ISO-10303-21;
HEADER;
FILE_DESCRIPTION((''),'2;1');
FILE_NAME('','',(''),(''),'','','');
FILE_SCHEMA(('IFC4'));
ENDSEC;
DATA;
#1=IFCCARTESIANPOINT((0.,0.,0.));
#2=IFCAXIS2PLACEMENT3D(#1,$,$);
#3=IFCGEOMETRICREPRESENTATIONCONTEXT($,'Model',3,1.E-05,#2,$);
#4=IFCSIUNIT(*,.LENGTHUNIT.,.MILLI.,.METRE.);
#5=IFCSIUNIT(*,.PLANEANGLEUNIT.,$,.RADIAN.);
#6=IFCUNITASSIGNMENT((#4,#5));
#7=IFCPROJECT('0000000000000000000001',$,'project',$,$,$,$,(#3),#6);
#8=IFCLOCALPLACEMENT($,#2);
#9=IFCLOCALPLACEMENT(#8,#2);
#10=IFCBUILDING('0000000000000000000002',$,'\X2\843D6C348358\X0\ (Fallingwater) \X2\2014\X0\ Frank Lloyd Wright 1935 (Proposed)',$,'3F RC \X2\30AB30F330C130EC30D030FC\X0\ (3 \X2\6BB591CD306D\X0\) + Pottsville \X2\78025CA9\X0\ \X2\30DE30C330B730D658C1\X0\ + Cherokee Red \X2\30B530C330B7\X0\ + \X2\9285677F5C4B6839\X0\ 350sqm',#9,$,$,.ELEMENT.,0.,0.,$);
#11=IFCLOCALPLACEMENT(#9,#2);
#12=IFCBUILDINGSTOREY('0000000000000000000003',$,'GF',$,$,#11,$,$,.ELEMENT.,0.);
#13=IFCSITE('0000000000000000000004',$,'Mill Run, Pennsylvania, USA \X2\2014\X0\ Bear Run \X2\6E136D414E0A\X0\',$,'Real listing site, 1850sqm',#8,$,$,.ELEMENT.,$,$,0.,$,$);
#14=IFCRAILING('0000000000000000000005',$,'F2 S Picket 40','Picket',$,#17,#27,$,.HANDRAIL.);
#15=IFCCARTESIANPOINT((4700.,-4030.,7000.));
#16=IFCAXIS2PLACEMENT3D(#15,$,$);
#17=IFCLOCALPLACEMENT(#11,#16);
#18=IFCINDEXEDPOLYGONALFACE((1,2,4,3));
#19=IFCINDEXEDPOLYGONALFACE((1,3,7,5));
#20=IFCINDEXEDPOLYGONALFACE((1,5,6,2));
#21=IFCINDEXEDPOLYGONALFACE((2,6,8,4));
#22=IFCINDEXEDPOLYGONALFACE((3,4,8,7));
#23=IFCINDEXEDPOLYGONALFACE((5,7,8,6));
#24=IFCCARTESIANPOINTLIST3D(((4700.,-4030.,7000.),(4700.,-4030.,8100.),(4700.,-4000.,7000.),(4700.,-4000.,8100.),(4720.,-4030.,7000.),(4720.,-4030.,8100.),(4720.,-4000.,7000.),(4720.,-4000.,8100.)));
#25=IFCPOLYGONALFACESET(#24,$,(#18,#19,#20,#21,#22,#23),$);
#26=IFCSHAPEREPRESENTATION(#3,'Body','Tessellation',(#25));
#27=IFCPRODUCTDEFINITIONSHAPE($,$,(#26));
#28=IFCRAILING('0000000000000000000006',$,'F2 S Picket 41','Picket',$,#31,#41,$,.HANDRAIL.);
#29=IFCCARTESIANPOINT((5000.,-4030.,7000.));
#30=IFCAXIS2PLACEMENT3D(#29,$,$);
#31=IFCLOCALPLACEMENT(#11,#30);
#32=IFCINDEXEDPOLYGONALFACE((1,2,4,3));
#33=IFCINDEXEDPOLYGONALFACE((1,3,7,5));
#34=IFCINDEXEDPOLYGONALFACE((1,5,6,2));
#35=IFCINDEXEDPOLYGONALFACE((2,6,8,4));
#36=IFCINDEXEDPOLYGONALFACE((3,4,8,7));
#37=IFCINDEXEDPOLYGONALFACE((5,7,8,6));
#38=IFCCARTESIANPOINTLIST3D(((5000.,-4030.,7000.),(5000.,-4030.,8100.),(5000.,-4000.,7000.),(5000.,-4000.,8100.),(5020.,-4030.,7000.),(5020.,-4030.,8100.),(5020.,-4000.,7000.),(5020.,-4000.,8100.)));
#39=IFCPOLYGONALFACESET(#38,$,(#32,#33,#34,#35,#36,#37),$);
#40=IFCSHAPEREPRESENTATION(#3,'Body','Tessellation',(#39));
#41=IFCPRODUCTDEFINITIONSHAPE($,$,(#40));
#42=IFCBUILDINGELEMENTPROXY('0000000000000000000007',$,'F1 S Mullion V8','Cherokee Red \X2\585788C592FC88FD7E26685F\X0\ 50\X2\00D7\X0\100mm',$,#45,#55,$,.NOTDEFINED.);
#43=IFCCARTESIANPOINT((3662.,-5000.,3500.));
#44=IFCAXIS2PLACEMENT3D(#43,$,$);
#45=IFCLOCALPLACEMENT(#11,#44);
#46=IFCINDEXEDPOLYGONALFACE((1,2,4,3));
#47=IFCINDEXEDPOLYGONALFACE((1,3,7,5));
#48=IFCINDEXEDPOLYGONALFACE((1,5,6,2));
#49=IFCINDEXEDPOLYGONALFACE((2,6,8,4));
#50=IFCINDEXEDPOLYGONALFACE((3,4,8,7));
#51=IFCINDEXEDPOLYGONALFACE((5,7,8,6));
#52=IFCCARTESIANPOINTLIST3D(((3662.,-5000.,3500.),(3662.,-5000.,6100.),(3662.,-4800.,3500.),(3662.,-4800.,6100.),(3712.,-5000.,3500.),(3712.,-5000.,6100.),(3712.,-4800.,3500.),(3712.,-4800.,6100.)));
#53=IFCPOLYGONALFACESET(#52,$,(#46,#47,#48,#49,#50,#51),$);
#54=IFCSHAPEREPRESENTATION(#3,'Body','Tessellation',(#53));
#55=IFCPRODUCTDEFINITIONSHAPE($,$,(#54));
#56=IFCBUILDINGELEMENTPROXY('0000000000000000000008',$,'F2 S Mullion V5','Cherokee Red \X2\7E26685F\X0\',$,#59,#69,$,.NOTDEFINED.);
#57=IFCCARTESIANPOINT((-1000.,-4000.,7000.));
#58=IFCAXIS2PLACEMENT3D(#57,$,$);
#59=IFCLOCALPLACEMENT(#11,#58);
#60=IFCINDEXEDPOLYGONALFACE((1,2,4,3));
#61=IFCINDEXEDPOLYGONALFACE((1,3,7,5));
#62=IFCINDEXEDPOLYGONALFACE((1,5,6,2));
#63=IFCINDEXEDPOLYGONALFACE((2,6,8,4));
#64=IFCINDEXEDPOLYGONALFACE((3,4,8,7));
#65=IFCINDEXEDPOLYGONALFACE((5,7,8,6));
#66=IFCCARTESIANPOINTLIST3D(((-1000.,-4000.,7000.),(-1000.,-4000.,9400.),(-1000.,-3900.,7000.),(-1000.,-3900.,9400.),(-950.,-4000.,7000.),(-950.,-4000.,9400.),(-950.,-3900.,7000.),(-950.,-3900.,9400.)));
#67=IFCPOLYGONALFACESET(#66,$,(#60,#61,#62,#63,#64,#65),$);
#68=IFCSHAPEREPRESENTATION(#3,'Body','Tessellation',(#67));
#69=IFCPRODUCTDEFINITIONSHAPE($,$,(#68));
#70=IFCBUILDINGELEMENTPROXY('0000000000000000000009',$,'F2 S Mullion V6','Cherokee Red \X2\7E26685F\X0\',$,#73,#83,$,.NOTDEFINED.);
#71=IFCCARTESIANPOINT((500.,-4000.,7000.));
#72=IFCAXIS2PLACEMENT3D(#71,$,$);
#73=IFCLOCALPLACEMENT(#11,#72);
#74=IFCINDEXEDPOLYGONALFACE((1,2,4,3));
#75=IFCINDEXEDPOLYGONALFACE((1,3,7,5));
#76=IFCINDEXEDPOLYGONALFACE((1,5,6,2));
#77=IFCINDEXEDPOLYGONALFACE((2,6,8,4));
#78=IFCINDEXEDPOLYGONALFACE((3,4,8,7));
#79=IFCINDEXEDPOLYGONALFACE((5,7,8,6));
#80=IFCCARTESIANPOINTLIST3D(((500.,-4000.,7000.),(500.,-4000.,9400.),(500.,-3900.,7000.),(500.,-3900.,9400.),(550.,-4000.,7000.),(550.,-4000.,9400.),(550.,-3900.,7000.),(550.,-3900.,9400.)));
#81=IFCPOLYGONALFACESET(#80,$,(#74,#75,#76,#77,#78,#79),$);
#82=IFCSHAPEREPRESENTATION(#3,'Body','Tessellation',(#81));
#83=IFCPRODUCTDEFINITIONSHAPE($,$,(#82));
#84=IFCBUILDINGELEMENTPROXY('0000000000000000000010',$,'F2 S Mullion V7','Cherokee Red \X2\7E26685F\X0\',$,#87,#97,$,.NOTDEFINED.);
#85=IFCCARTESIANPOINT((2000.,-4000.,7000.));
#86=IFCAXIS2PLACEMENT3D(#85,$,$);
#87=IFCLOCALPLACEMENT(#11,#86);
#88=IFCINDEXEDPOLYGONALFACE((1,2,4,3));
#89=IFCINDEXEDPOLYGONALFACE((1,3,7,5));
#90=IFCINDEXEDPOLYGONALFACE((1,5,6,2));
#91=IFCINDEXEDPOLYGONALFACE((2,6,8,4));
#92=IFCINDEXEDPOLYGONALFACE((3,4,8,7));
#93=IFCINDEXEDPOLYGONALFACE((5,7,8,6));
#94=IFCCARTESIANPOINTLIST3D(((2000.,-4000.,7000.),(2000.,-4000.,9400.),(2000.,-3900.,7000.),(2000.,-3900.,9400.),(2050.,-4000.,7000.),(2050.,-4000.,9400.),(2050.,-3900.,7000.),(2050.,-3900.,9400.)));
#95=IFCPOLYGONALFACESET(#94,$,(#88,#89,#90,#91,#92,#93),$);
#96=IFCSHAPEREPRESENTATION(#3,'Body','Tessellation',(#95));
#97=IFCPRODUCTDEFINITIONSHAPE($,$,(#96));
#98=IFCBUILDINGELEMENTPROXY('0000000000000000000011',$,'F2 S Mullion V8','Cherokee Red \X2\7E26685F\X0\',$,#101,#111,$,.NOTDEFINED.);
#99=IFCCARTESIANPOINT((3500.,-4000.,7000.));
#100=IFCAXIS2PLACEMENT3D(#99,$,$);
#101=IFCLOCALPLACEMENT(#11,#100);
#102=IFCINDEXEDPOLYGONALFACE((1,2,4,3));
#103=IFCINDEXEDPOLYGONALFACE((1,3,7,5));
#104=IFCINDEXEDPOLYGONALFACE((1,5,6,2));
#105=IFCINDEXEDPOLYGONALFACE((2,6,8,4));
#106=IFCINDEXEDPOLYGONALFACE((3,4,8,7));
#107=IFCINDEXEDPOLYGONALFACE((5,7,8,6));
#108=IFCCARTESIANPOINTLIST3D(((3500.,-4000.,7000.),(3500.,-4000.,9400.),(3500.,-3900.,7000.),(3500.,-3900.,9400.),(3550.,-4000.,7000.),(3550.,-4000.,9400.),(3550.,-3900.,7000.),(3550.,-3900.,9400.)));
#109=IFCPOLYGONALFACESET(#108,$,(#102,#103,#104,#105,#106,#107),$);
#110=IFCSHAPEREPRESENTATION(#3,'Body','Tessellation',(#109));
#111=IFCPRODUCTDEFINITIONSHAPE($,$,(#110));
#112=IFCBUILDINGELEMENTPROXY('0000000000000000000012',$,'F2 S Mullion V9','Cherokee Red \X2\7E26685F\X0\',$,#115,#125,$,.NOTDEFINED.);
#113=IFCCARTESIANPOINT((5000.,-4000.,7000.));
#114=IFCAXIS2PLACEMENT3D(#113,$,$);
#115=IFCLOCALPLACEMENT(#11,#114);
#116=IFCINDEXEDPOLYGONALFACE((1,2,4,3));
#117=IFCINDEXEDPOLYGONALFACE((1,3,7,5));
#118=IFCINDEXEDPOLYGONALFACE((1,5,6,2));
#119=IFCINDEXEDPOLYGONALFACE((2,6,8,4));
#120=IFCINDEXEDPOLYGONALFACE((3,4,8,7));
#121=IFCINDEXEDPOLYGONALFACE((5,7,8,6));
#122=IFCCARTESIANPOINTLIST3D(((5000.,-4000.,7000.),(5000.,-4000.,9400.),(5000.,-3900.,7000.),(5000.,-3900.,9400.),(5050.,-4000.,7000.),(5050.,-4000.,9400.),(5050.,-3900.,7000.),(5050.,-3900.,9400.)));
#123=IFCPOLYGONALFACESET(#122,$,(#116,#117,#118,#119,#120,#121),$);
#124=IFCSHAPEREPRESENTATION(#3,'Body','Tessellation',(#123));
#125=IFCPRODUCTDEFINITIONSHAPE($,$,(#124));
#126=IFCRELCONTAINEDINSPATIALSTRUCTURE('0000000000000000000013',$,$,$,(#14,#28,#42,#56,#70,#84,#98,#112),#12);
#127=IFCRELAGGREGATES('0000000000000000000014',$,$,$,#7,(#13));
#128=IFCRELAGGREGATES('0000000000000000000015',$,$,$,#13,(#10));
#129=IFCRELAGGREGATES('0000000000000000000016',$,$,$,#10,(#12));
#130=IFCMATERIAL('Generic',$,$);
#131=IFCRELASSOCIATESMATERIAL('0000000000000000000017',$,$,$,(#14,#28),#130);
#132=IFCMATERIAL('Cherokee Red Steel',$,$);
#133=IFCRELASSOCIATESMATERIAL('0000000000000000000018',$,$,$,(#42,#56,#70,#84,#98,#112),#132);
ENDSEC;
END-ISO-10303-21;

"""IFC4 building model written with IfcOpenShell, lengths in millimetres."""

from ifc_helpers import new_model, si_unit, frame, frame_2d, origin, place, context, project, spatial, rectangle, extrude, material, element, save


model = new_model("IFC4")

# Units and contexts
model_context = context("Model", 3, precision=1e-05, world=origin())
ifc_project = project(units=[si_unit("LENGTHUNIT", "METRE", prefix="MILLI"), si_unit("PLANEANGLEUNIT", "RADIAN")], contexts=[model_context])

# Site, building, storey
site_placement = place(None, origin())
site = spatial("IfcSite", under=ifc_project, at=site_placement, Name="Mill Run, Pennsylvania, USA — Bear Run 渓流上", ObjectType="Real listing site, 1850sqm", CompositionType="ELEMENT", RefElevation=0.0)
building_placement = place(site_placement, origin())
building = spatial("IfcBuilding", under=site, at=building_placement, Name="落水荘 (Fallingwater) — Frank Lloyd Wright 1935 (Proposed)", ObjectType="3F RC カンチレバー (3 段重ね) + Pottsville 砂岩 マッシブ壁 + Cherokee Red サッシ + 銅板屋根 350sqm", CompositionType="ELEMENT", ElevationOfRefHeight=0.0, ElevationOfTerrain=0.0)
storey_placement = place(building_placement, origin())
storey = spatial("IfcBuildingStorey", under=building, at=storey_placement, Name="GF", CompositionType="ELEMENT", Elevation=0.0)

# Shared definitions
ifc_material_1 = material(Name="Cherokee Red Steel")

# Railings
ifc_material_2 = material(Name="Generic")
railing_1_placement = place(storey_placement, frame((4700.0, -4030.0, 7000.0)))
element("IfcRailing", 1, at=railing_1_placement, inside=storey, material=ifc_material_2, Name="F2 S Picket 40", Description="Picket", PredefinedType="HANDRAIL", context=model_context, shape_type="SweptSolid", body=[
    extrude(rectangle(XDim=20.0, YDim=30.0, at=frame_2d((10.0, 15.0))), frame((4700.0, -4030.0, 7000.0)), (0.0, 0.0, 1.0), 1100.0),
])
railing_2_placement = place(storey_placement, frame((5000.0, -4030.0, 7000.0)))
element("IfcRailing", 2, at=railing_2_placement, inside=storey, material=ifc_material_2, Name="F2 S Picket 41", Description="Picket", PredefinedType="HANDRAIL", context=model_context, shape_type="SweptSolid", body=[
    extrude(rectangle(XDim=20.0, YDim=30.0, at=frame_2d((10.0, 15.0))), frame((5000.0, -4030.0, 7000.0)), (0.0, 0.0, 1.0), 1100.0),
])

# Building element proxies
proxy_1_placement = place(storey_placement, frame((3662.0, -5000.0, 3500.0)))
element("IfcBuildingElementProxy", 3, at=proxy_1_placement, inside=storey, material=ifc_material_1, Name="F1 S Mullion V8", Description="Cherokee Red 塗装鋼製縦桟 50×100mm", PredefinedType="NOTDEFINED", context=model_context, shape_type="SweptSolid", body=[
    extrude(rectangle(XDim=50.0, YDim=200.0, at=frame_2d((25.0, 100.0))), frame((3662.0, -5000.0, 3500.0)), (0.0, 0.0, 1.0), 2600.0),
])
proxy_2_placement = place(storey_placement, frame((-1000.0, -4000.0, 7000.0)))
element("IfcBuildingElementProxy", 4, at=proxy_2_placement, inside=storey, material=ifc_material_1, Name="F2 S Mullion V5", Description="Cherokee Red 縦桟", PredefinedType="NOTDEFINED", context=model_context, shape_type="SweptSolid", body=[
    extrude(rectangle(XDim=50.0, YDim=100.0, at=frame_2d((25.0, 50.0))), frame((-1000.0, -4000.0, 7000.0)), (0.0, 0.0, 1.0), 2400.0),
])
proxy_3_placement = place(storey_placement, frame((500.0, -4000.0, 7000.0)))
element("IfcBuildingElementProxy", 5, at=proxy_3_placement, inside=storey, material=ifc_material_1, Name="F2 S Mullion V6", Description="Cherokee Red 縦桟", PredefinedType="NOTDEFINED", context=model_context, shape_type="SweptSolid", body=[
    extrude(rectangle(XDim=50.0, YDim=100.0, at=frame_2d((25.0, 50.0))), frame((500.0, -4000.0, 7000.0)), (0.0, 0.0, 1.0), 2400.0),
])
proxy_4_placement = place(storey_placement, frame((2000.0, -4000.0, 7000.0)))
element("IfcBuildingElementProxy", 6, at=proxy_4_placement, inside=storey, material=ifc_material_1, Name="F2 S Mullion V7", Description="Cherokee Red 縦桟", PredefinedType="NOTDEFINED", context=model_context, shape_type="SweptSolid", body=[
    extrude(rectangle(XDim=50.0, YDim=100.0, at=frame_2d((25.0, 50.0))), frame((2000.0, -4000.0, 7000.0)), (0.0, 0.0, 1.0), 2400.0),
])
proxy_5_placement = place(storey_placement, frame((3500.0, -4000.0, 7000.0)))
element("IfcBuildingElementProxy", 7, at=proxy_5_placement, inside=storey, material=ifc_material_1, Name="F2 S Mullion V8", Description="Cherokee Red 縦桟", PredefinedType="NOTDEFINED", context=model_context, shape_type="SweptSolid", body=[
    extrude(rectangle(XDim=50.0, YDim=100.0, at=frame_2d((25.0, 50.0))), frame((3500.0, -4000.0, 7000.0)), (0.0, 0.0, 1.0), 2400.0),
])
proxy_6_placement = place(storey_placement, frame((5000.0, -4000.0, 7000.0)))
element("IfcBuildingElementProxy", 8, at=proxy_6_placement, inside=storey, material=ifc_material_1, Name="F2 S Mullion V9", Description="Cherokee Red 縦桟", PredefinedType="NOTDEFINED", context=model_context, shape_type="SweptSolid", body=[
    extrude(rectangle(XDim=50.0, YDim=100.0, at=frame_2d((25.0, 50.0))), frame((5000.0, -4000.0, 7000.0)), (0.0, 0.0, 1.0), 2400.0),
])

save(model, "model.ifc")
